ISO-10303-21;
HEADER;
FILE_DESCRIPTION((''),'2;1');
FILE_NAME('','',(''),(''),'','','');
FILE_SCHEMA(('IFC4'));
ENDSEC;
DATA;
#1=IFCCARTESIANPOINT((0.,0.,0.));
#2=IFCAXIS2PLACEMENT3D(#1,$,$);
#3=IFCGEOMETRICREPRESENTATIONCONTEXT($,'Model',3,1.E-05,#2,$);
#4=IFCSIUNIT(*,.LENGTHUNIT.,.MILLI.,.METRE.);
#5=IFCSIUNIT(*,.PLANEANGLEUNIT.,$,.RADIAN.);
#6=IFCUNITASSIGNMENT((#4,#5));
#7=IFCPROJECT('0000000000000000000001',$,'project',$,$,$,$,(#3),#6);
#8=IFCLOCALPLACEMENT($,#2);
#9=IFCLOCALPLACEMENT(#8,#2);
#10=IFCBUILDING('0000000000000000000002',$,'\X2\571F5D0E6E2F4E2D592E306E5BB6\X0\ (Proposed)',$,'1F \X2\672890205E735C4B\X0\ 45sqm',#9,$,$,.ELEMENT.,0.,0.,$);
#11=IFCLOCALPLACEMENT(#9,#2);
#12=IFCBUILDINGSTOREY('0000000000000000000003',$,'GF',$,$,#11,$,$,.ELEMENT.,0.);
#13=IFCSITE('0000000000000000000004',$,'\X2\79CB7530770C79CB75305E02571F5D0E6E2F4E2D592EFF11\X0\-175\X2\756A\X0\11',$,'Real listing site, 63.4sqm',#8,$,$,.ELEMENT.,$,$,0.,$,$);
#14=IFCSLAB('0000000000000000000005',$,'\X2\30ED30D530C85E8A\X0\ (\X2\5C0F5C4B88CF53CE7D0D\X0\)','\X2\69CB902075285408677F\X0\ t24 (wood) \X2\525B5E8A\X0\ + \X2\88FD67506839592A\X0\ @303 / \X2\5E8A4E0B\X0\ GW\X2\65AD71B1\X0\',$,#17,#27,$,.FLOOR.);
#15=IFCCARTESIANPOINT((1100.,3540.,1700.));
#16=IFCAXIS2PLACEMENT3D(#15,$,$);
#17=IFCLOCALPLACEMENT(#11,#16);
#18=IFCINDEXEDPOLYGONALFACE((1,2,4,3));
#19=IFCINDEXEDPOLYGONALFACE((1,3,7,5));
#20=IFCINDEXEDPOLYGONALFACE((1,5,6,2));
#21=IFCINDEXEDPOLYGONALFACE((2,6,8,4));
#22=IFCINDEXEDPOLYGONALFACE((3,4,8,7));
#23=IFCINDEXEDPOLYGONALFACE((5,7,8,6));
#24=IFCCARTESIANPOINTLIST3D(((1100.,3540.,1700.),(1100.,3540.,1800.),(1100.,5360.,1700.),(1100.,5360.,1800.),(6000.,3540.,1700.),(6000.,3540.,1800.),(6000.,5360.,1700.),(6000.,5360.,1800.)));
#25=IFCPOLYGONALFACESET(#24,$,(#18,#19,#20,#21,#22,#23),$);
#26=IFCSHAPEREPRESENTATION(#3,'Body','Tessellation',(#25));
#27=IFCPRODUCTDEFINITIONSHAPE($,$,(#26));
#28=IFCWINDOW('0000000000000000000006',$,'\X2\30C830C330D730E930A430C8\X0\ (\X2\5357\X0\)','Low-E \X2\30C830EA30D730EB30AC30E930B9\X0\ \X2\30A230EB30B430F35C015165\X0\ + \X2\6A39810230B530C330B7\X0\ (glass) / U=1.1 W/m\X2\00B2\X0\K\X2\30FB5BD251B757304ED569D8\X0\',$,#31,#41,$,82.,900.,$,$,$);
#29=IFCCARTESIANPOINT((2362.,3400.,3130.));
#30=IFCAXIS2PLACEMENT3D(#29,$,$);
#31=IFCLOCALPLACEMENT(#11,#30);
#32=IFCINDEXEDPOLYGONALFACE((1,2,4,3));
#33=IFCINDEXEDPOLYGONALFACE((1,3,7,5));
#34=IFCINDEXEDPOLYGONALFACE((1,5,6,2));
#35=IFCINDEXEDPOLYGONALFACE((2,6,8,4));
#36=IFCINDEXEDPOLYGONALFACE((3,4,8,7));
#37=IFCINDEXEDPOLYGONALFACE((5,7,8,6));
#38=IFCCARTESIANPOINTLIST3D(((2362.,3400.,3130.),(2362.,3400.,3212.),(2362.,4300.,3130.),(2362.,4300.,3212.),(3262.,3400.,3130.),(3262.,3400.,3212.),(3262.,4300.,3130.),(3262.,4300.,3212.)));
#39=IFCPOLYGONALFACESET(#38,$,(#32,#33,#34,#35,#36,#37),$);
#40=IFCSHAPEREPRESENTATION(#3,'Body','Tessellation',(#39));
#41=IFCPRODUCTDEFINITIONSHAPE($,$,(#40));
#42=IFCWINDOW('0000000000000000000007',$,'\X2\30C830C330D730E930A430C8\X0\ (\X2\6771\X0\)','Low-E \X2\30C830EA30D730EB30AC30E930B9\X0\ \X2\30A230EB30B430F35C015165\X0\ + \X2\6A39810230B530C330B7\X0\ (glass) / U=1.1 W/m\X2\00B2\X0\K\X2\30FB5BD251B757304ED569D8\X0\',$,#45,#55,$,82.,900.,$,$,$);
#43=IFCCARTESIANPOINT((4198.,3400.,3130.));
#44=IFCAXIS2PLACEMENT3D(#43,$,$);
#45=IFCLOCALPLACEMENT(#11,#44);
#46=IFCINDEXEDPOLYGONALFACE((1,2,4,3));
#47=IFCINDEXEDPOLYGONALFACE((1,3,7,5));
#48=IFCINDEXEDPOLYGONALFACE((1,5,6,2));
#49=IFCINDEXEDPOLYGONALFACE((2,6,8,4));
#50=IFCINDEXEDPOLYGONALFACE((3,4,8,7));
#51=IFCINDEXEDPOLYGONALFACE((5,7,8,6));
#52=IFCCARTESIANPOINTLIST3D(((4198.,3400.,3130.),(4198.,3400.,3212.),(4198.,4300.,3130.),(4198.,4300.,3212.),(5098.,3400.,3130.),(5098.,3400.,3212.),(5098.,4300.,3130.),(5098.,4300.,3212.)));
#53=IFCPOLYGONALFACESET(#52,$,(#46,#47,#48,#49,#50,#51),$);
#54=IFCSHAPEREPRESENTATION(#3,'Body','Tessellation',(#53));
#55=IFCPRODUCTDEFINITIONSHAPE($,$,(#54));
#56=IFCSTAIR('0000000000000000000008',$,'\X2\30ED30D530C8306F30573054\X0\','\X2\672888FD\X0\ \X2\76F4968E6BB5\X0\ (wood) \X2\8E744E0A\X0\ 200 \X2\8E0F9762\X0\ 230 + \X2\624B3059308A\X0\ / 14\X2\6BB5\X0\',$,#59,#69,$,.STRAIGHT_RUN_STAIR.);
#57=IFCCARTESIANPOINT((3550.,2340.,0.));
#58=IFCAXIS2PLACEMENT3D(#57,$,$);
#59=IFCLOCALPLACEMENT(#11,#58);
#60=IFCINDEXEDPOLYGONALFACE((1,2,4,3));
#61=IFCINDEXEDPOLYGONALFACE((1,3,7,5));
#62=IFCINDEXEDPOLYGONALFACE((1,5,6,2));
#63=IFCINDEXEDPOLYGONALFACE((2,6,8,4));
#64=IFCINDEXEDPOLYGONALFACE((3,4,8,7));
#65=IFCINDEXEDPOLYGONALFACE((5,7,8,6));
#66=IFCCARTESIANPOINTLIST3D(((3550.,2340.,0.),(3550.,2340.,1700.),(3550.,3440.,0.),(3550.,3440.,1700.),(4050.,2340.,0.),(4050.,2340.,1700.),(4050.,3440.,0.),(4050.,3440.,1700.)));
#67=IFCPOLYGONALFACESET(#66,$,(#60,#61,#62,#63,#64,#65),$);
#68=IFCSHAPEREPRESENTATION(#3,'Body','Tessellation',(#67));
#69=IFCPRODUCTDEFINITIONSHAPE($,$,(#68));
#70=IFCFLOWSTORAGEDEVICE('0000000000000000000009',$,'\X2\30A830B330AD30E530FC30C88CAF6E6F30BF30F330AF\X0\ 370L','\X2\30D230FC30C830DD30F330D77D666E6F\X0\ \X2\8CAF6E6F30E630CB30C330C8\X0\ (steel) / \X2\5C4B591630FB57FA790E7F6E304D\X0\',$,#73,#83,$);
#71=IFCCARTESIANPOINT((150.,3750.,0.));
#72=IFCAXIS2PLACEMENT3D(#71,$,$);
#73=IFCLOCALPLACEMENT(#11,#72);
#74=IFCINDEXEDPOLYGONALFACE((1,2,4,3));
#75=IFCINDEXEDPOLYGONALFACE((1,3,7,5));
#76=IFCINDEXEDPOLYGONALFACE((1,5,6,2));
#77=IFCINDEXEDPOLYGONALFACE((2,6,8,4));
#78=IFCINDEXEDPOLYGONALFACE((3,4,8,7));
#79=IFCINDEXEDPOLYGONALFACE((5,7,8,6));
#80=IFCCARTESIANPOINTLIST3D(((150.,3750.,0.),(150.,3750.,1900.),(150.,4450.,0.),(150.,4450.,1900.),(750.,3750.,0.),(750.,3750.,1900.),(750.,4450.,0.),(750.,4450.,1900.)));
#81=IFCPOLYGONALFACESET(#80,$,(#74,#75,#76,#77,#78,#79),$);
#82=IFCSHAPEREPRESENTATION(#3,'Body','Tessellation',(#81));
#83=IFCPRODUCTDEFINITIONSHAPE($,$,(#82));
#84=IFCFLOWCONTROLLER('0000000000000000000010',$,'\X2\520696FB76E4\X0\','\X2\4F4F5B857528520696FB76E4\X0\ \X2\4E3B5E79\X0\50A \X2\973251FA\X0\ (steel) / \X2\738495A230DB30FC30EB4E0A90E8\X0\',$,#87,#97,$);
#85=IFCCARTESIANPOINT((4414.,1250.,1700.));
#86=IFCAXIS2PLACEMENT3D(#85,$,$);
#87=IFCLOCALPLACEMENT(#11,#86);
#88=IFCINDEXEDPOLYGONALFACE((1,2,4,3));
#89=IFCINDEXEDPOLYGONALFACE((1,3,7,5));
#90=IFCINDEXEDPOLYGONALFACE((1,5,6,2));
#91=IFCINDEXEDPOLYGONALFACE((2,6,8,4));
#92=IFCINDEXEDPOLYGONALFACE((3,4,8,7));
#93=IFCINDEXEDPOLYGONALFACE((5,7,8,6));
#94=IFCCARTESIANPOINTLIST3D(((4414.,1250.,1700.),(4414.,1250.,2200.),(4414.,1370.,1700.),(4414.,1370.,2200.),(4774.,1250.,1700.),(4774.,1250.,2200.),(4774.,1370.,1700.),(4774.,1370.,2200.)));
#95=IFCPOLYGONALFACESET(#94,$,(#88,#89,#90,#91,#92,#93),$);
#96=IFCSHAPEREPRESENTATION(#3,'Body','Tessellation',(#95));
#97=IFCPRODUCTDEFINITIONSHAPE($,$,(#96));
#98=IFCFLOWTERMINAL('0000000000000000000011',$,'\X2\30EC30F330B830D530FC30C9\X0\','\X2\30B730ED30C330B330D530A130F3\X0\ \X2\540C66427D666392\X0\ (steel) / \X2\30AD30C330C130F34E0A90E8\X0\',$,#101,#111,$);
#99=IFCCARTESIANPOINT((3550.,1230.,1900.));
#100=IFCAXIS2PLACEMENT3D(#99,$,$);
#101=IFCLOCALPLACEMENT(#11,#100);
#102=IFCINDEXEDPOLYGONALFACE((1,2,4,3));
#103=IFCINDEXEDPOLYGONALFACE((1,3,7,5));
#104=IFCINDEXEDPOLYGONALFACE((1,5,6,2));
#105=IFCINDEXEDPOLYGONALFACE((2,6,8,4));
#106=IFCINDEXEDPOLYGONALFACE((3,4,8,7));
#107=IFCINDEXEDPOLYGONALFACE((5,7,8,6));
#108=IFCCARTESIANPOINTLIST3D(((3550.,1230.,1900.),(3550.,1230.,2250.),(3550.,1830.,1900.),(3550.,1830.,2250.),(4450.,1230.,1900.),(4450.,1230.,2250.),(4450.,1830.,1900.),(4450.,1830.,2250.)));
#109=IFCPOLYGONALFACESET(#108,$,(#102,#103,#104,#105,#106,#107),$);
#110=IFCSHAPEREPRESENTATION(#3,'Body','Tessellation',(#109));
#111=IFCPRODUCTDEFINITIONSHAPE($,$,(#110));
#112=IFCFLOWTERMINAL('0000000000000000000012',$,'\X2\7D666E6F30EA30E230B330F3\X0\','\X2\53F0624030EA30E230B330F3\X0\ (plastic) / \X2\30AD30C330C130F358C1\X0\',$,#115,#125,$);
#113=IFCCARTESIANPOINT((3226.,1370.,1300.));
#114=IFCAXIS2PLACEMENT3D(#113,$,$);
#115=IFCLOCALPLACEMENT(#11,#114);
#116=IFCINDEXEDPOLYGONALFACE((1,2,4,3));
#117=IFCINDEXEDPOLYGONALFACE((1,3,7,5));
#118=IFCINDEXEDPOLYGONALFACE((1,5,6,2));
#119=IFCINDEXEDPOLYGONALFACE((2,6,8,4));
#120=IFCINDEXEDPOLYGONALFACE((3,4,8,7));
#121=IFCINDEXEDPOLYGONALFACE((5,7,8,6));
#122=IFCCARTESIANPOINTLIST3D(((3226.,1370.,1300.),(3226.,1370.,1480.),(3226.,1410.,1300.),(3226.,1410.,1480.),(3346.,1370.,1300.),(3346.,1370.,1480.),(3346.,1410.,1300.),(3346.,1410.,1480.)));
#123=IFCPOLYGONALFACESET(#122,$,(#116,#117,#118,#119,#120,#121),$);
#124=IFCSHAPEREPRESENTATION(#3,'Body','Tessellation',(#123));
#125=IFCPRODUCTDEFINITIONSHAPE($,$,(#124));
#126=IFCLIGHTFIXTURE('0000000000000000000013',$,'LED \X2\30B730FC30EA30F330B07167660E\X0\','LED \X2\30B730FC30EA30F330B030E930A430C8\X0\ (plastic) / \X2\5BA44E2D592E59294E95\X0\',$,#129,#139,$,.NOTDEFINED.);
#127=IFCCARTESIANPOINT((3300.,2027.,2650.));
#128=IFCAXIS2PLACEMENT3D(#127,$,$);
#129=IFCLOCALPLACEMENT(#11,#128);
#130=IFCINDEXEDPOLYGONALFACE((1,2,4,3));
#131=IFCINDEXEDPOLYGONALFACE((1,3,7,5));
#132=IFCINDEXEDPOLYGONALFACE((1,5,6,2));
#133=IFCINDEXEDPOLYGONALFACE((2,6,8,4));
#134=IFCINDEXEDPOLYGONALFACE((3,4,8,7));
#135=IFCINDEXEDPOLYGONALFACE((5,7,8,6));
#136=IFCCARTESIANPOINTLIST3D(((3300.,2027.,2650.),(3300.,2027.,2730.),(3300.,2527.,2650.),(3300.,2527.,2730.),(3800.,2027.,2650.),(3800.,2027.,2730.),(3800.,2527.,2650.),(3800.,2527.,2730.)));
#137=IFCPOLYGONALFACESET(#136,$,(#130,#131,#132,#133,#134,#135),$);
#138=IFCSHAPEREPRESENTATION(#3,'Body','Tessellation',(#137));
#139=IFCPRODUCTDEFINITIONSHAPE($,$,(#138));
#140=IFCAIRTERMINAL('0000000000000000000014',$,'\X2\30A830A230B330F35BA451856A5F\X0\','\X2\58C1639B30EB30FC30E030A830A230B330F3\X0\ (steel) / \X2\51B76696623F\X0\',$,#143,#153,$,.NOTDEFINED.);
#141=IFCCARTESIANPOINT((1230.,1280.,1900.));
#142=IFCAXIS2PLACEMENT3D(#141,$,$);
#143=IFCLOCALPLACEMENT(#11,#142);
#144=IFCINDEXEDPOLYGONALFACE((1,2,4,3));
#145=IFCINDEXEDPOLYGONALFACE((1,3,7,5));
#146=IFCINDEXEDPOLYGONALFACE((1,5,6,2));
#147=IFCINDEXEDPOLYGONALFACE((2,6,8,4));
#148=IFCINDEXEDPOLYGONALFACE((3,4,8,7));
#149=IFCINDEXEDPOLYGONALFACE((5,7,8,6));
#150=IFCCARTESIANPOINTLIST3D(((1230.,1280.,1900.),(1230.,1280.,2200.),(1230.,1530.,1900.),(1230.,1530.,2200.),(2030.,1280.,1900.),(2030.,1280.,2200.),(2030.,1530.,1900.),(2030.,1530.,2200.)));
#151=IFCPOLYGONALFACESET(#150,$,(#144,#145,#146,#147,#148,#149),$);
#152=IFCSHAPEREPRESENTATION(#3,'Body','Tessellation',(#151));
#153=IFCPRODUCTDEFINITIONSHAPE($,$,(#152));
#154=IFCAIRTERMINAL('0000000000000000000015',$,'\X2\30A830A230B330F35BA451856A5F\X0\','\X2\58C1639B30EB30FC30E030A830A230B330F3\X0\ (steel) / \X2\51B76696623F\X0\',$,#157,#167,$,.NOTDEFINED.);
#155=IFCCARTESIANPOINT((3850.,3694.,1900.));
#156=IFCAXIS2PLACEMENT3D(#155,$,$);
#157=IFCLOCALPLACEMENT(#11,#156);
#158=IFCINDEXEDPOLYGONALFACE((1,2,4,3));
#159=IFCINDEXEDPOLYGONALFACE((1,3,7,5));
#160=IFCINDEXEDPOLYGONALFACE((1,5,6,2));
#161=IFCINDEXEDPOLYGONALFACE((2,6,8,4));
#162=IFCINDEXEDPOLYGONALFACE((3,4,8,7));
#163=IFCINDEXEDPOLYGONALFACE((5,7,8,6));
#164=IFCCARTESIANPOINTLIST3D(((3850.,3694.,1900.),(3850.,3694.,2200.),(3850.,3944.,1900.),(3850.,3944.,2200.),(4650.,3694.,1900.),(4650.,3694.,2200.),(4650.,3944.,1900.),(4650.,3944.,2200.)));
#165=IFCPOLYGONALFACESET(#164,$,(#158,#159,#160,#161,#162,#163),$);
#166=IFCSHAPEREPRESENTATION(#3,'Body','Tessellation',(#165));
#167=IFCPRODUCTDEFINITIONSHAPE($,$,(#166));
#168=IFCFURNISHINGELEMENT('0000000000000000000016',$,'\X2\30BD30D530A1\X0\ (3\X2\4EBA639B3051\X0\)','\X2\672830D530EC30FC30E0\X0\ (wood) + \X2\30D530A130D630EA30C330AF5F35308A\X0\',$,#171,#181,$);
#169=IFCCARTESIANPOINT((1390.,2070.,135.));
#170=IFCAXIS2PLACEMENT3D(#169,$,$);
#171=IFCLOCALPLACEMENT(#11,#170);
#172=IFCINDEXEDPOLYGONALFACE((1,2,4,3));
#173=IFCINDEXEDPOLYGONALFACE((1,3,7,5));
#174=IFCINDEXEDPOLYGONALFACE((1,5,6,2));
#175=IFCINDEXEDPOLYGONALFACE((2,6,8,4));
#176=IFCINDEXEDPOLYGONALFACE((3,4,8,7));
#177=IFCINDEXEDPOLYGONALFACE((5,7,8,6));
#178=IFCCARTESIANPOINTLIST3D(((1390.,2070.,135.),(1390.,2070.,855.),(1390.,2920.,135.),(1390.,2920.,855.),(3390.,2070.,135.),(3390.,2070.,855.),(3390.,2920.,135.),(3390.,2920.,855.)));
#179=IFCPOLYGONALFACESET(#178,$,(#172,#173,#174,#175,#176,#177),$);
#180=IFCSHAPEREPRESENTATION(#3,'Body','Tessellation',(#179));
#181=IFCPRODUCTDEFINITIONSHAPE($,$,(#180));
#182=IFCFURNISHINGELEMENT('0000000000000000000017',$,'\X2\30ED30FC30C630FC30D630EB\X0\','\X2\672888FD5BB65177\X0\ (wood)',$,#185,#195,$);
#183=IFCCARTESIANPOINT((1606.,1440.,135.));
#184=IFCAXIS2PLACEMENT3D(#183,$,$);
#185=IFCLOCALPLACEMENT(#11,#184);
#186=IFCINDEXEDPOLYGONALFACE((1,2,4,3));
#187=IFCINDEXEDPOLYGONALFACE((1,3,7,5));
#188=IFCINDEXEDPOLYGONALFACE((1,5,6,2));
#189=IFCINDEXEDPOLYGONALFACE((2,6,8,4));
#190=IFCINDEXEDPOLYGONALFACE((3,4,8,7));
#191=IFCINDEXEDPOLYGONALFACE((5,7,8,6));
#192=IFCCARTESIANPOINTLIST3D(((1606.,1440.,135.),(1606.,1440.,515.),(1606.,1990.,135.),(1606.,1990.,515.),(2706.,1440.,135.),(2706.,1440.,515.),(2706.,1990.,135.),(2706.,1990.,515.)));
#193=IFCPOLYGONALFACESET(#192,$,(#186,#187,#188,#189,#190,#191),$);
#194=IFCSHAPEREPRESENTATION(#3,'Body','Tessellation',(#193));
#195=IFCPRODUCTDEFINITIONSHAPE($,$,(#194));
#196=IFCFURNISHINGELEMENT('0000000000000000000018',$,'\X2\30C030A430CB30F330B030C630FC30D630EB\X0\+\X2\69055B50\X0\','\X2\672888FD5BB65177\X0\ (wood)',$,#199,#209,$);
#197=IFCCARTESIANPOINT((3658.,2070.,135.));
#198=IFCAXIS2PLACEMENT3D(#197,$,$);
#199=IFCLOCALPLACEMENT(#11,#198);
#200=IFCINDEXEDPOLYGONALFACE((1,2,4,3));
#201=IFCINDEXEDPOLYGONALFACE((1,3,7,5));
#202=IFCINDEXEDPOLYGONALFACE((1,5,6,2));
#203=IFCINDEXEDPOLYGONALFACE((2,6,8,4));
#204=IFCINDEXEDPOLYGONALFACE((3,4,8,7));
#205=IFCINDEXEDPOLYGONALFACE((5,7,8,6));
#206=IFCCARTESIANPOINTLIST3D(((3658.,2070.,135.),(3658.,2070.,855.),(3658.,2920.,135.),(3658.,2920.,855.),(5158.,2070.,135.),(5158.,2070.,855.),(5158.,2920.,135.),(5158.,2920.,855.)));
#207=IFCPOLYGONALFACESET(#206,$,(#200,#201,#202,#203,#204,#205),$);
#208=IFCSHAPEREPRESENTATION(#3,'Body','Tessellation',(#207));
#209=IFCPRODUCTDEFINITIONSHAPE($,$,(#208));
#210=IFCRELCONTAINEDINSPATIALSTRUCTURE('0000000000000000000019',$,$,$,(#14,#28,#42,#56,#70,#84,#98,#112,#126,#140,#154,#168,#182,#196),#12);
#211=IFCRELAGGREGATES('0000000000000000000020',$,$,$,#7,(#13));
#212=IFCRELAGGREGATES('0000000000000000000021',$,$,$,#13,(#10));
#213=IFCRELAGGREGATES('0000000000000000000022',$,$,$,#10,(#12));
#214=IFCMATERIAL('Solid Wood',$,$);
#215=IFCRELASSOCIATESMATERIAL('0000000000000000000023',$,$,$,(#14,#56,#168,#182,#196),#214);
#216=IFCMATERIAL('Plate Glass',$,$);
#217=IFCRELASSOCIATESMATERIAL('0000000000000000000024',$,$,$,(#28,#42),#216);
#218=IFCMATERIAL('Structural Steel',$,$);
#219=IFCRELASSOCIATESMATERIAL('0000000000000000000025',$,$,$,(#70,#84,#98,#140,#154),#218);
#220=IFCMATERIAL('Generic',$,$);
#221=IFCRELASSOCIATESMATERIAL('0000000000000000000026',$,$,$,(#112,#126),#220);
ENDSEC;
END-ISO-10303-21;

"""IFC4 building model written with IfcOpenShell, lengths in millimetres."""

from ifc_helpers import new_model, si_unit, frame, frame_2d, origin, place, context, project, spatial, rectangle, extrude, material, element, save


model = new_model("IFC4")

# Units and contexts
model_context = context("Model", 3, precision=1e-05, world=origin())
ifc_project = project(units=[si_unit("LENGTHUNIT", "METRE", prefix="MILLI"), si_unit("PLANEANGLEUNIT", "RADIAN")], contexts=[model_context])

# Site, building, storey
site_placement = place(None, origin())
site = spatial("IfcSite", under=ifc_project, at=site_placement, Name="秋田県秋田市土崎港中央１-175番11", ObjectType="Real listing site, 63.4sqm", CompositionType="ELEMENT", RefElevation=0.0)
building_placement = place(site_placement, origin())
building = spatial("IfcBuilding", under=site, at=building_placement, Name="土崎港中央の家 (Proposed)", ObjectType="1F 木造平屋 45sqm", CompositionType="ELEMENT", ElevationOfRefHeight=0.0, ElevationOfTerrain=0.0)
storey_placement = place(building_placement, origin())
storey = spatial("IfcBuildingStorey", under=building, at=storey_placement, Name="GF", CompositionType="ELEMENT", Elevation=0.0)

# Shared definitions
ifc_material_1 = material(Name="Solid Wood")

# Slab
slab_placement = place(storey_placement, frame((1100.0, 3540.0, 1700.0)))
element("IfcSlab", 1, at=slab_placement, inside=storey, material=ifc_material_1, Name="ロフト床 (小屋裏収納)", Description="構造用合板 t24 (wood) 剛床 + 製材根太 @303 / 床下 GW断熱", PredefinedType="FLOOR", context=model_context, shape_type="SweptSolid", body=[
    extrude(rectangle(XDim=4900.0, YDim=1820.0, at=frame_2d((2450.0, 910.0))), frame((1100.0, 3540.0, 1700.0)), (0.0, 0.0, 1.0), 100.0),
])

# Windows
ifc_material_2 = material(Name="Plate Glass")
window_1_placement = place(storey_placement, frame((2362.0, 3400.0, 3130.0)))
element("IfcWindow", 2, at=window_1_placement, inside=storey, material=ifc_material_2, Name="トップライト (南)", Description="Low-E トリプルガラス アルゴン封入 + 樹脂サッシ (glass) / U=1.1 W/m²K・寒冷地仕様", OverallHeight=82.0, OverallWidth=900.0, context=model_context, shape_type="SweptSolid", body=[
    extrude(rectangle(XDim=900.0, YDim=900.0, at=frame_2d((450.0, 450.0))), frame((2362.0, 3400.0, 3130.0)), (0.0, 0.0, 1.0), 82.0),
])
window_2_placement = place(storey_placement, frame((4198.0, 3400.0, 3130.0)))
element("IfcWindow", 3, at=window_2_placement, inside=storey, material=ifc_material_2, Name="トップライト (東)", Description="Low-E トリプルガラス アルゴン封入 + 樹脂サッシ (glass) / U=1.1 W/m²K・寒冷地仕様", OverallHeight=82.0, OverallWidth=900.0, context=model_context, shape_type="SweptSolid", body=[
    extrude(rectangle(XDim=900.0, YDim=900.0, at=frame_2d((450.0, 450.0))), frame((4198.0, 3400.0, 3130.0)), (0.0, 0.0, 1.0), 82.0),
])

# Stair
stair_placement = place(storey_placement, frame((3550.0, 2340.0, 0.0)))
element("IfcStair", 4, at=stair_placement, inside=storey, material=ifc_material_1, Name="ロフトはしご", Description="木製 直階段 (wood) 蹴上 200 踏面 230 + 手すり / 14段", PredefinedType="STRAIGHT_RUN_STAIR", context=model_context, shape_type="SweptSolid", body=[
    extrude(rectangle(XDim=500.0, YDim=1100.0, at=frame_2d((250.0, 550.0))), frame((3550.0, 2340.0, 0.0)), (0.0, 0.0, 1.0), 1700.0),
])

# Flow storage device
ifc_material_3 = material(Name="Structural Steel")
flow_storage_device_placement = place(storey_placement, frame((150.0, 3750.0, 0.0)))
element("IfcFlowStorageDevice", 5, at=flow_storage_device_placement, inside=storey, material=ifc_material_3, Name="エコキュート貯湯タンク 370L", Description="ヒートポンプ給湯 貯湯ユニット (steel) / 屋外・基礎置き", context=model_context, shape_type="SweptSolid", body=[
    extrude(rectangle(XDim=600.0, YDim=700.0, at=frame_2d((300.0, 350.0))), frame((150.0, 3750.0, 0.0)), (0.0, 0.0, 1.0), 1900.0),
])

# Flow controller
flow_controller_placement = place(storey_placement, frame((4414.0, 1250.0, 1700.0)))
element("IfcFlowController", 6, at=flow_controller_placement, inside=storey, material=ifc_material_3, Name="分電盤", Description="住宅用分電盤 主幹50A 露出 (steel) / 玄関ホール上部", context=model_context, shape_type="SweptSolid", body=[
    extrude(rectangle(XDim=360.0, YDim=120.0, at=frame_2d((180.0, 60.0))), frame((4414.0, 1250.0, 1700.0)), (0.0, 0.0, 1.0), 500.0),
])

# Flow terminals
flow_terminal_1_placement = place(storey_placement, frame((3550.0, 1230.0, 1900.0)))
element("IfcFlowTerminal", 7, at=flow_terminal_1_placement, inside=storey, material=ifc_material_3, Name="レンジフード", Description="シロッコファン 同時給排 (steel) / キッチン上部", context=model_context, shape_type="SweptSolid", body=[
    extrude(rectangle(XDim=900.0, YDim=600.0, at=frame_2d((450.0, 300.0))), frame((3550.0, 1230.0, 1900.0)), (0.0, 0.0, 1.0), 350.0),
])
ifc_material_4 = material(Name="Generic")
flow_terminal_2_placement = place(storey_placement, frame((3226.0, 1370.0, 1300.0)))
element("IfcFlowTerminal", 8, at=flow_terminal_2_placement, inside=storey, material=ifc_material_4, Name="給湯リモコン", Description="台所リモコン (plastic) / キッチン壁", context=model_context, shape_type="SweptSolid", body=[
    extrude(rectangle(XDim=120.0, YDim=40.0, at=frame_2d((60.0, 20.0))), frame((3226.0, 1370.0, 1300.0)), (0.0, 0.0, 1.0), 180.0),
])

# Light fixture
light_fixture_placement = place(storey_placement, frame((3300.0, 2027.0, 2650.0)))
element("IfcLightFixture", 9, at=light_fixture_placement, inside=storey, material=ifc_material_4, Name="LED シーリング照明", Description="LED シーリングライト (plastic) / 室中央天井", PredefinedType="NOTDEFINED", context=model_context, shape_type="SweptSolid", body=[
    extrude(rectangle(XDim=500.0, YDim=500.0, at=frame_2d((250.0, 250.0))), frame((3300.0, 2027.0, 2650.0)), (0.0, 0.0, 1.0), 80.0),
])

# Air terminals
air_terminal_1_placement = place(storey_placement, frame((1230.0, 1280.0, 1900.0)))
element("IfcAirTerminal", 10, at=air_terminal_1_placement, inside=storey, material=ifc_material_3, Name="エアコン室内機", Description="壁掛ルームエアコン (steel) / 冷暖房", PredefinedType="NOTDEFINED", context=model_context, shape_type="SweptSolid", body=[
    extrude(rectangle(XDim=800.0, YDim=250.0, at=frame_2d((400.0, 125.0))), frame((1230.0, 1280.0, 1900.0)), (0.0, 0.0, 1.0), 300.0),
])
air_terminal_2_placement = place(storey_placement, frame((3850.0, 3694.0, 1900.0)))
element("IfcAirTerminal", 11, at=air_terminal_2_placement, inside=storey, material=ifc_material_3, Name="エアコン室内機", Description="壁掛ルームエアコン (steel) / 冷暖房", PredefinedType="NOTDEFINED", context=model_context, shape_type="SweptSolid", body=[
    extrude(rectangle(XDim=800.0, YDim=250.0, at=frame_2d((400.0, 125.0))), frame((3850.0, 3694.0, 1900.0)), (0.0, 0.0, 1.0), 300.0),
])

# Furnishing elements
furnishing_1_placement = place(storey_placement, frame((1390.0, 2070.0, 135.0)))
element("IfcFurnishingElement", 12, at=furnishing_1_placement, inside=storey, material=ifc_material_1, Name="ソファ (3人掛け)", Description="木フレーム (wood) + ファブリック張り", context=model_context, shape_type="SweptSolid", body=[
    extrude(rectangle(XDim=2000.0, YDim=850.0, at=frame_2d((1000.0, 425.0))), frame((1390.0, 2070.0, 135.0)), (0.0, 0.0, 1.0), 720.0),
])
furnishing_2_placement = place(storey_placement, frame((1606.0, 1440.0, 135.0)))
element("IfcFurnishingElement", 13, at=furnishing_2_placement, inside=storey, material=ifc_material_1, Name="ローテーブル", Description="木製家具 (wood)", context=model_context, shape_type="SweptSolid", body=[
    extrude(rectangle(XDim=1100.0, YDim=550.0, at=frame_2d((550.0, 275.0))), frame((1606.0, 1440.0, 135.0)), (0.0, 0.0, 1.0), 380.0),
])
furnishing_3_placement = place(storey_placement, frame((3658.0, 2070.0, 135.0)))
element("IfcFurnishingElement", 14, at=furnishing_3_placement, inside=storey, material=ifc_material_1, Name="ダイニングテーブル+椅子", Description="木製家具 (wood)", context=model_context, shape_type="SweptSolid", body=[
    extrude(rectangle(XDim=1500.0, YDim=850.0, at=frame_2d((750.0, 425.0))), frame((3658.0, 2070.0, 135.0)), (0.0, 0.0, 1.0), 720.0),
])

save(model, "model.ifc")
